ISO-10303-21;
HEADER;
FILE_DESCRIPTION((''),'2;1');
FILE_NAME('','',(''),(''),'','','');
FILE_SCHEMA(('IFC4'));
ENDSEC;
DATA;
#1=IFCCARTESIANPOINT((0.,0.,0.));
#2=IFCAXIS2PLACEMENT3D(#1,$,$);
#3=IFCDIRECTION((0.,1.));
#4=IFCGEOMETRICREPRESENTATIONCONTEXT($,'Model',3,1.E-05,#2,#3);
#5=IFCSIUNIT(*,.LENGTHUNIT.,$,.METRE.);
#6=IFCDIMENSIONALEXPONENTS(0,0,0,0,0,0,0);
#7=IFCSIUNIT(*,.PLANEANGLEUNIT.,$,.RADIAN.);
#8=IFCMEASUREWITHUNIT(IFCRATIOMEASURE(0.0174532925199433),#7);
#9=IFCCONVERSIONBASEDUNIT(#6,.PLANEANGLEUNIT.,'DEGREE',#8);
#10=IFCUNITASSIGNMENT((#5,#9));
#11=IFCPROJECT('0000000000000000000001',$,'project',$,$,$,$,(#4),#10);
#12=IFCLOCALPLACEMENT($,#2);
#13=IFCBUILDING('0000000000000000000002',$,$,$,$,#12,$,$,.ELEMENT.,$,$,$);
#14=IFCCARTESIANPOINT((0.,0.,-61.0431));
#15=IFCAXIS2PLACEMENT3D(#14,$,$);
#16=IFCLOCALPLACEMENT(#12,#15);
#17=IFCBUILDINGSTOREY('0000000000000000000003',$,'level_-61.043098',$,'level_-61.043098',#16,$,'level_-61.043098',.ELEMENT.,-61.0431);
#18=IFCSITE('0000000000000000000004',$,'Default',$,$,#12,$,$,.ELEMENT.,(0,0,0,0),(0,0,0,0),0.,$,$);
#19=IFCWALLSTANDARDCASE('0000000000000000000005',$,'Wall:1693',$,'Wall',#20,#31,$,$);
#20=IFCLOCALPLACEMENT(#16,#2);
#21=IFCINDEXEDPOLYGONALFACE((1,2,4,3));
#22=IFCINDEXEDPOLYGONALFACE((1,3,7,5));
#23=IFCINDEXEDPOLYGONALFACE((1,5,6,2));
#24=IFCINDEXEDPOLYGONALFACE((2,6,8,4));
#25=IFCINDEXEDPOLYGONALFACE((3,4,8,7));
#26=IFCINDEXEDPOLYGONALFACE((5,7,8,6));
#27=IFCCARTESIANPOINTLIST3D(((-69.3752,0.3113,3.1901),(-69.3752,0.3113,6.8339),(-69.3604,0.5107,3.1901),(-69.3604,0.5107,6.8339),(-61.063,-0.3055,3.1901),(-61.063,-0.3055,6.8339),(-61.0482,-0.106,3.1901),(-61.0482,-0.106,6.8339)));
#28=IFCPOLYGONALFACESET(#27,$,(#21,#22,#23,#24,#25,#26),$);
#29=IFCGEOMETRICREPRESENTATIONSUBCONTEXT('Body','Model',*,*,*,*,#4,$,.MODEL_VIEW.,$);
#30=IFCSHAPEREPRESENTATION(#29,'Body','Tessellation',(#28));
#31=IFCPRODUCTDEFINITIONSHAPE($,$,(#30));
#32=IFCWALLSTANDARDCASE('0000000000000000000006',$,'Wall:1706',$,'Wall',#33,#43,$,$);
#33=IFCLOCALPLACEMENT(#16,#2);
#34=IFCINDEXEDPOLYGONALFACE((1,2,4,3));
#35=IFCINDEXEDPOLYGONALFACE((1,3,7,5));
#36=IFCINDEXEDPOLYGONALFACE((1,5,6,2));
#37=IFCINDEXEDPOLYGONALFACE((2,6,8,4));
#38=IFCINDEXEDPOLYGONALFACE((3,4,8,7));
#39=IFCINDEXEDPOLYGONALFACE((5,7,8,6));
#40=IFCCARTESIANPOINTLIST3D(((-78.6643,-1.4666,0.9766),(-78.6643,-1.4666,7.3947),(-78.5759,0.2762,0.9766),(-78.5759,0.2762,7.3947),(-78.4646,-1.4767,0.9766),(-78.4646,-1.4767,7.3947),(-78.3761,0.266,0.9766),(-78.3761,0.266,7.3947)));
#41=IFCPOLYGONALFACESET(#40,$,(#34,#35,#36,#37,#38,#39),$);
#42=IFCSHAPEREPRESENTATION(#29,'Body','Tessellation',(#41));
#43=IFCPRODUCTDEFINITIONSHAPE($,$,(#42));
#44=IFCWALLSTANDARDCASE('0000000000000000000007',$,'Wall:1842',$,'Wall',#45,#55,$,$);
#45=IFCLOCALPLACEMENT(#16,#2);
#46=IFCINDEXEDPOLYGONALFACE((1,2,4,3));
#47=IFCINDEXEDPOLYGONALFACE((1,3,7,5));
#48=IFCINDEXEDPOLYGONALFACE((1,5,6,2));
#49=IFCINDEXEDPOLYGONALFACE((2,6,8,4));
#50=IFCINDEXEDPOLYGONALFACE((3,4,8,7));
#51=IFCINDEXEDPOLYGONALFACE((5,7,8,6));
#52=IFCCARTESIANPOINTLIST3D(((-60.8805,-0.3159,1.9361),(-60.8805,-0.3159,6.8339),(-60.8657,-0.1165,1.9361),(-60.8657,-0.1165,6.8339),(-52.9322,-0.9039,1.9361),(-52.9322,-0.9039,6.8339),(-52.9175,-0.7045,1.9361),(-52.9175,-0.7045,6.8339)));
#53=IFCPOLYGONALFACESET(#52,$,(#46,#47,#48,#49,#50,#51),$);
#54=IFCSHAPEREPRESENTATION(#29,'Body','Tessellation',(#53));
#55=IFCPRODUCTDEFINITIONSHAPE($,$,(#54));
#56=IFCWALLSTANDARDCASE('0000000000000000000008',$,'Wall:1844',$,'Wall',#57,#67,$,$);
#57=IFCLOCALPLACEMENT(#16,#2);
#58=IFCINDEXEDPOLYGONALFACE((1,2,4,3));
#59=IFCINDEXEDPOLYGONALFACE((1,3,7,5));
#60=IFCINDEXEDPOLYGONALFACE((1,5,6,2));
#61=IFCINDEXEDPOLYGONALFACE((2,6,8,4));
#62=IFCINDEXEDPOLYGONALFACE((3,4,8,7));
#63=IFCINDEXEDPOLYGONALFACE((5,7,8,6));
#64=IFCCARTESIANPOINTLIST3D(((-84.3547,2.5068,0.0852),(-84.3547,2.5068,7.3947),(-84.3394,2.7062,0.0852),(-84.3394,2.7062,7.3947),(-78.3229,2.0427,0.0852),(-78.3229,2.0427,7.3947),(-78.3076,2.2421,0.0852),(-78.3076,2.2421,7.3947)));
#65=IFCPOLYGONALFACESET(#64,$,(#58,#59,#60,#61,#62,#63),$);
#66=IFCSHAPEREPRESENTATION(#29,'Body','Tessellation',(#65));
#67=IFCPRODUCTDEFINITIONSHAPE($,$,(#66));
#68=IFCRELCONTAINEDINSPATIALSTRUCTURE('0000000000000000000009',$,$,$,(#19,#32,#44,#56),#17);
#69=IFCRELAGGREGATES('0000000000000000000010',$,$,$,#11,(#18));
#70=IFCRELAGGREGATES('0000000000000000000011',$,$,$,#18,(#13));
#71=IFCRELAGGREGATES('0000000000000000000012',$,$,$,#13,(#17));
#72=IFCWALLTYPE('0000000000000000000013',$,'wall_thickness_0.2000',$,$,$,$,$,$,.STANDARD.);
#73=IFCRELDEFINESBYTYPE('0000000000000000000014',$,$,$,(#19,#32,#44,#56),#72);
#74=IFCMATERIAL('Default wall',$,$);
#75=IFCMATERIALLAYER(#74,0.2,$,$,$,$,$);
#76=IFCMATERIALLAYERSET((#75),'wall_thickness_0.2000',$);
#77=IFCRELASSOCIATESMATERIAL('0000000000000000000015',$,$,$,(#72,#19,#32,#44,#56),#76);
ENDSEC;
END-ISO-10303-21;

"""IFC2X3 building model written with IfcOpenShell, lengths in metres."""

from ifc_helpers import new_model, entity, si_unit, converted_unit, direction, frame, origin, place, context, subcontext, project, spatial, polyline, outline, extrude, material, layer, layer_set, layer_usage, type_object, element, save


model = new_model("IFC2X3")

# Units and contexts
model_context = context("Model", 3, precision=1e-05, world=origin(), true_north=direction((0.0, 1.0)))
body_context = subcontext(model_context, "Body", "Model", "MODEL_VIEW")
ifc_project = project(units=[si_unit("LENGTHUNIT", "METRE"), converted_unit("PLANEANGLEUNIT", "DEGREE", entity("IfcRatioMeasure", 0.0174532925199433), si_unit("PLANEANGLEUNIT", "RADIAN"), dimensions=[0, 0, 0, 0, 0, 0, 0])], contexts=[model_context])

# Site, building, storey
placement_1 = place(None, origin())
site = spatial("IfcSite", under=ifc_project, at=placement_1, Name="Default", CompositionType="ELEMENT", RefLatitude=(0, 0, 0, 0), RefLongitude=(0, 0, 0, 0), RefElevation=0.0)
building = spatial("IfcBuilding", under=site, at=placement_1, CompositionType="ELEMENT")
storey_placement = place(placement_1, frame((0.0, 0.0, -61.0431)))
storey = spatial("IfcBuildingStorey", under=building, at=storey_placement, Name="level_-61.043098", ObjectType="level_-61.043098", LongName="level_-61.043098", CompositionType="ELEMENT", Elevation=-61.0431)

# Shared definitions
ifc_material_1 = material(Name="Default wall")
ifc_layer = layer(ifc_material_1, 0.2)
ifc_layer_set = layer_set([ifc_layer], Name="wall_thickness_0.2000")
ifc_layer_usage = layer_usage(ifc_layer_set, "AXIS2", "POSITIVE", -0.1)
wall_type = type_object("IfcWallType", Name="wall_thickness_0.2000", PredefinedType="STANDARD", material=ifc_layer_set)

# Walls
placement_2 = place(placement_1, frame((0.0, 0.0, -57.853)))
wall_1_placement = place(placement_2, frame((-69.3678, 0.411, 0.0), z_axis=(0.0, 0.0, 1.0), x_axis=(0.997258, -0.073997, 0.0)))
element("IfcWallStandardCase", 1, at=wall_1_placement, inside=storey, type_object=wall_type, material=ifc_layer_usage, Name="Wall:1693", ObjectType="Wall", context=body_context, shape_type="SweptSolid", body=[
    extrude(outline(polyline([(8.335, -0.1), (8.335, 0.1), (0.0, 0.1), (0.0, -0.1), (8.335, -0.1)])), origin(), (0.0, 0.0, 1.0), 3.6438),
])
placement_3 = place(placement_1, frame((0.0, 0.0, -60.0665)))
wall_2_placement = place(placement_3, frame((-78.5644, -1.4717, 0.0), z_axis=(0.0, 0.0, 1.0), x_axis=(0.050686, 0.998715, 0.0)))
element("IfcWallStandardCase", 2, at=wall_2_placement, inside=storey, type_object=wall_type, material=ifc_layer_usage, Name="Wall:1706", ObjectType="Wall", context=body_context, shape_type="SweptSolid", body=[
    extrude(outline(polyline([(1.745, -0.1), (1.745, 0.1), (0.0, 0.1), (0.0, -0.1), (1.745, -0.1)])), origin(), (0.0, 0.0, 1.0), 6.4181),
])
placement_4 = place(placement_1, frame((0.0, 0.0, -59.107)))
wall_3_placement = place(placement_4, frame((-60.8731, -0.2162, 0.0), z_axis=(0.0, 0.0, 1.0), x_axis=(0.997275, -0.073779, 0.0)))
element("IfcWallStandardCase", 3, at=wall_3_placement, inside=storey, type_object=wall_type, material=ifc_layer_usage, Name="Wall:1842", ObjectType="Wall", context=body_context, shape_type="SweptSolid", body=[
    extrude(outline(polyline([(7.97, -0.1), (7.97, 0.1), (0.0, 0.1), (0.0, -0.1), (7.97, -0.1)])), origin(), (0.0, 0.0, 1.0), 4.8979),
])
placement_5 = place(placement_1, frame((0.0, 0.0, -60.9579)))
wall_4_placement = place(placement_5, frame((-78.3153, 2.1424, 0.0), z_axis=(0.0, 0.0, 1.0), x_axis=(-0.997053, 0.076719, 0.0)))
element("IfcWallStandardCase", 4, at=wall_4_placement, inside=storey, type_object=wall_type, material=ifc_layer_usage, Name="Wall:1844", ObjectType="Wall", context=body_context, shape_type="SweptSolid", body=[
    extrude(outline(polyline([(6.0496, -0.1), (6.0496, 0.1), (0.0, 0.1), (0.0, -0.1), (6.0496, -0.1)])), origin(), (0.0, 0.0, 1.0), 7.3095),
])

save(model, "model.ifc")
